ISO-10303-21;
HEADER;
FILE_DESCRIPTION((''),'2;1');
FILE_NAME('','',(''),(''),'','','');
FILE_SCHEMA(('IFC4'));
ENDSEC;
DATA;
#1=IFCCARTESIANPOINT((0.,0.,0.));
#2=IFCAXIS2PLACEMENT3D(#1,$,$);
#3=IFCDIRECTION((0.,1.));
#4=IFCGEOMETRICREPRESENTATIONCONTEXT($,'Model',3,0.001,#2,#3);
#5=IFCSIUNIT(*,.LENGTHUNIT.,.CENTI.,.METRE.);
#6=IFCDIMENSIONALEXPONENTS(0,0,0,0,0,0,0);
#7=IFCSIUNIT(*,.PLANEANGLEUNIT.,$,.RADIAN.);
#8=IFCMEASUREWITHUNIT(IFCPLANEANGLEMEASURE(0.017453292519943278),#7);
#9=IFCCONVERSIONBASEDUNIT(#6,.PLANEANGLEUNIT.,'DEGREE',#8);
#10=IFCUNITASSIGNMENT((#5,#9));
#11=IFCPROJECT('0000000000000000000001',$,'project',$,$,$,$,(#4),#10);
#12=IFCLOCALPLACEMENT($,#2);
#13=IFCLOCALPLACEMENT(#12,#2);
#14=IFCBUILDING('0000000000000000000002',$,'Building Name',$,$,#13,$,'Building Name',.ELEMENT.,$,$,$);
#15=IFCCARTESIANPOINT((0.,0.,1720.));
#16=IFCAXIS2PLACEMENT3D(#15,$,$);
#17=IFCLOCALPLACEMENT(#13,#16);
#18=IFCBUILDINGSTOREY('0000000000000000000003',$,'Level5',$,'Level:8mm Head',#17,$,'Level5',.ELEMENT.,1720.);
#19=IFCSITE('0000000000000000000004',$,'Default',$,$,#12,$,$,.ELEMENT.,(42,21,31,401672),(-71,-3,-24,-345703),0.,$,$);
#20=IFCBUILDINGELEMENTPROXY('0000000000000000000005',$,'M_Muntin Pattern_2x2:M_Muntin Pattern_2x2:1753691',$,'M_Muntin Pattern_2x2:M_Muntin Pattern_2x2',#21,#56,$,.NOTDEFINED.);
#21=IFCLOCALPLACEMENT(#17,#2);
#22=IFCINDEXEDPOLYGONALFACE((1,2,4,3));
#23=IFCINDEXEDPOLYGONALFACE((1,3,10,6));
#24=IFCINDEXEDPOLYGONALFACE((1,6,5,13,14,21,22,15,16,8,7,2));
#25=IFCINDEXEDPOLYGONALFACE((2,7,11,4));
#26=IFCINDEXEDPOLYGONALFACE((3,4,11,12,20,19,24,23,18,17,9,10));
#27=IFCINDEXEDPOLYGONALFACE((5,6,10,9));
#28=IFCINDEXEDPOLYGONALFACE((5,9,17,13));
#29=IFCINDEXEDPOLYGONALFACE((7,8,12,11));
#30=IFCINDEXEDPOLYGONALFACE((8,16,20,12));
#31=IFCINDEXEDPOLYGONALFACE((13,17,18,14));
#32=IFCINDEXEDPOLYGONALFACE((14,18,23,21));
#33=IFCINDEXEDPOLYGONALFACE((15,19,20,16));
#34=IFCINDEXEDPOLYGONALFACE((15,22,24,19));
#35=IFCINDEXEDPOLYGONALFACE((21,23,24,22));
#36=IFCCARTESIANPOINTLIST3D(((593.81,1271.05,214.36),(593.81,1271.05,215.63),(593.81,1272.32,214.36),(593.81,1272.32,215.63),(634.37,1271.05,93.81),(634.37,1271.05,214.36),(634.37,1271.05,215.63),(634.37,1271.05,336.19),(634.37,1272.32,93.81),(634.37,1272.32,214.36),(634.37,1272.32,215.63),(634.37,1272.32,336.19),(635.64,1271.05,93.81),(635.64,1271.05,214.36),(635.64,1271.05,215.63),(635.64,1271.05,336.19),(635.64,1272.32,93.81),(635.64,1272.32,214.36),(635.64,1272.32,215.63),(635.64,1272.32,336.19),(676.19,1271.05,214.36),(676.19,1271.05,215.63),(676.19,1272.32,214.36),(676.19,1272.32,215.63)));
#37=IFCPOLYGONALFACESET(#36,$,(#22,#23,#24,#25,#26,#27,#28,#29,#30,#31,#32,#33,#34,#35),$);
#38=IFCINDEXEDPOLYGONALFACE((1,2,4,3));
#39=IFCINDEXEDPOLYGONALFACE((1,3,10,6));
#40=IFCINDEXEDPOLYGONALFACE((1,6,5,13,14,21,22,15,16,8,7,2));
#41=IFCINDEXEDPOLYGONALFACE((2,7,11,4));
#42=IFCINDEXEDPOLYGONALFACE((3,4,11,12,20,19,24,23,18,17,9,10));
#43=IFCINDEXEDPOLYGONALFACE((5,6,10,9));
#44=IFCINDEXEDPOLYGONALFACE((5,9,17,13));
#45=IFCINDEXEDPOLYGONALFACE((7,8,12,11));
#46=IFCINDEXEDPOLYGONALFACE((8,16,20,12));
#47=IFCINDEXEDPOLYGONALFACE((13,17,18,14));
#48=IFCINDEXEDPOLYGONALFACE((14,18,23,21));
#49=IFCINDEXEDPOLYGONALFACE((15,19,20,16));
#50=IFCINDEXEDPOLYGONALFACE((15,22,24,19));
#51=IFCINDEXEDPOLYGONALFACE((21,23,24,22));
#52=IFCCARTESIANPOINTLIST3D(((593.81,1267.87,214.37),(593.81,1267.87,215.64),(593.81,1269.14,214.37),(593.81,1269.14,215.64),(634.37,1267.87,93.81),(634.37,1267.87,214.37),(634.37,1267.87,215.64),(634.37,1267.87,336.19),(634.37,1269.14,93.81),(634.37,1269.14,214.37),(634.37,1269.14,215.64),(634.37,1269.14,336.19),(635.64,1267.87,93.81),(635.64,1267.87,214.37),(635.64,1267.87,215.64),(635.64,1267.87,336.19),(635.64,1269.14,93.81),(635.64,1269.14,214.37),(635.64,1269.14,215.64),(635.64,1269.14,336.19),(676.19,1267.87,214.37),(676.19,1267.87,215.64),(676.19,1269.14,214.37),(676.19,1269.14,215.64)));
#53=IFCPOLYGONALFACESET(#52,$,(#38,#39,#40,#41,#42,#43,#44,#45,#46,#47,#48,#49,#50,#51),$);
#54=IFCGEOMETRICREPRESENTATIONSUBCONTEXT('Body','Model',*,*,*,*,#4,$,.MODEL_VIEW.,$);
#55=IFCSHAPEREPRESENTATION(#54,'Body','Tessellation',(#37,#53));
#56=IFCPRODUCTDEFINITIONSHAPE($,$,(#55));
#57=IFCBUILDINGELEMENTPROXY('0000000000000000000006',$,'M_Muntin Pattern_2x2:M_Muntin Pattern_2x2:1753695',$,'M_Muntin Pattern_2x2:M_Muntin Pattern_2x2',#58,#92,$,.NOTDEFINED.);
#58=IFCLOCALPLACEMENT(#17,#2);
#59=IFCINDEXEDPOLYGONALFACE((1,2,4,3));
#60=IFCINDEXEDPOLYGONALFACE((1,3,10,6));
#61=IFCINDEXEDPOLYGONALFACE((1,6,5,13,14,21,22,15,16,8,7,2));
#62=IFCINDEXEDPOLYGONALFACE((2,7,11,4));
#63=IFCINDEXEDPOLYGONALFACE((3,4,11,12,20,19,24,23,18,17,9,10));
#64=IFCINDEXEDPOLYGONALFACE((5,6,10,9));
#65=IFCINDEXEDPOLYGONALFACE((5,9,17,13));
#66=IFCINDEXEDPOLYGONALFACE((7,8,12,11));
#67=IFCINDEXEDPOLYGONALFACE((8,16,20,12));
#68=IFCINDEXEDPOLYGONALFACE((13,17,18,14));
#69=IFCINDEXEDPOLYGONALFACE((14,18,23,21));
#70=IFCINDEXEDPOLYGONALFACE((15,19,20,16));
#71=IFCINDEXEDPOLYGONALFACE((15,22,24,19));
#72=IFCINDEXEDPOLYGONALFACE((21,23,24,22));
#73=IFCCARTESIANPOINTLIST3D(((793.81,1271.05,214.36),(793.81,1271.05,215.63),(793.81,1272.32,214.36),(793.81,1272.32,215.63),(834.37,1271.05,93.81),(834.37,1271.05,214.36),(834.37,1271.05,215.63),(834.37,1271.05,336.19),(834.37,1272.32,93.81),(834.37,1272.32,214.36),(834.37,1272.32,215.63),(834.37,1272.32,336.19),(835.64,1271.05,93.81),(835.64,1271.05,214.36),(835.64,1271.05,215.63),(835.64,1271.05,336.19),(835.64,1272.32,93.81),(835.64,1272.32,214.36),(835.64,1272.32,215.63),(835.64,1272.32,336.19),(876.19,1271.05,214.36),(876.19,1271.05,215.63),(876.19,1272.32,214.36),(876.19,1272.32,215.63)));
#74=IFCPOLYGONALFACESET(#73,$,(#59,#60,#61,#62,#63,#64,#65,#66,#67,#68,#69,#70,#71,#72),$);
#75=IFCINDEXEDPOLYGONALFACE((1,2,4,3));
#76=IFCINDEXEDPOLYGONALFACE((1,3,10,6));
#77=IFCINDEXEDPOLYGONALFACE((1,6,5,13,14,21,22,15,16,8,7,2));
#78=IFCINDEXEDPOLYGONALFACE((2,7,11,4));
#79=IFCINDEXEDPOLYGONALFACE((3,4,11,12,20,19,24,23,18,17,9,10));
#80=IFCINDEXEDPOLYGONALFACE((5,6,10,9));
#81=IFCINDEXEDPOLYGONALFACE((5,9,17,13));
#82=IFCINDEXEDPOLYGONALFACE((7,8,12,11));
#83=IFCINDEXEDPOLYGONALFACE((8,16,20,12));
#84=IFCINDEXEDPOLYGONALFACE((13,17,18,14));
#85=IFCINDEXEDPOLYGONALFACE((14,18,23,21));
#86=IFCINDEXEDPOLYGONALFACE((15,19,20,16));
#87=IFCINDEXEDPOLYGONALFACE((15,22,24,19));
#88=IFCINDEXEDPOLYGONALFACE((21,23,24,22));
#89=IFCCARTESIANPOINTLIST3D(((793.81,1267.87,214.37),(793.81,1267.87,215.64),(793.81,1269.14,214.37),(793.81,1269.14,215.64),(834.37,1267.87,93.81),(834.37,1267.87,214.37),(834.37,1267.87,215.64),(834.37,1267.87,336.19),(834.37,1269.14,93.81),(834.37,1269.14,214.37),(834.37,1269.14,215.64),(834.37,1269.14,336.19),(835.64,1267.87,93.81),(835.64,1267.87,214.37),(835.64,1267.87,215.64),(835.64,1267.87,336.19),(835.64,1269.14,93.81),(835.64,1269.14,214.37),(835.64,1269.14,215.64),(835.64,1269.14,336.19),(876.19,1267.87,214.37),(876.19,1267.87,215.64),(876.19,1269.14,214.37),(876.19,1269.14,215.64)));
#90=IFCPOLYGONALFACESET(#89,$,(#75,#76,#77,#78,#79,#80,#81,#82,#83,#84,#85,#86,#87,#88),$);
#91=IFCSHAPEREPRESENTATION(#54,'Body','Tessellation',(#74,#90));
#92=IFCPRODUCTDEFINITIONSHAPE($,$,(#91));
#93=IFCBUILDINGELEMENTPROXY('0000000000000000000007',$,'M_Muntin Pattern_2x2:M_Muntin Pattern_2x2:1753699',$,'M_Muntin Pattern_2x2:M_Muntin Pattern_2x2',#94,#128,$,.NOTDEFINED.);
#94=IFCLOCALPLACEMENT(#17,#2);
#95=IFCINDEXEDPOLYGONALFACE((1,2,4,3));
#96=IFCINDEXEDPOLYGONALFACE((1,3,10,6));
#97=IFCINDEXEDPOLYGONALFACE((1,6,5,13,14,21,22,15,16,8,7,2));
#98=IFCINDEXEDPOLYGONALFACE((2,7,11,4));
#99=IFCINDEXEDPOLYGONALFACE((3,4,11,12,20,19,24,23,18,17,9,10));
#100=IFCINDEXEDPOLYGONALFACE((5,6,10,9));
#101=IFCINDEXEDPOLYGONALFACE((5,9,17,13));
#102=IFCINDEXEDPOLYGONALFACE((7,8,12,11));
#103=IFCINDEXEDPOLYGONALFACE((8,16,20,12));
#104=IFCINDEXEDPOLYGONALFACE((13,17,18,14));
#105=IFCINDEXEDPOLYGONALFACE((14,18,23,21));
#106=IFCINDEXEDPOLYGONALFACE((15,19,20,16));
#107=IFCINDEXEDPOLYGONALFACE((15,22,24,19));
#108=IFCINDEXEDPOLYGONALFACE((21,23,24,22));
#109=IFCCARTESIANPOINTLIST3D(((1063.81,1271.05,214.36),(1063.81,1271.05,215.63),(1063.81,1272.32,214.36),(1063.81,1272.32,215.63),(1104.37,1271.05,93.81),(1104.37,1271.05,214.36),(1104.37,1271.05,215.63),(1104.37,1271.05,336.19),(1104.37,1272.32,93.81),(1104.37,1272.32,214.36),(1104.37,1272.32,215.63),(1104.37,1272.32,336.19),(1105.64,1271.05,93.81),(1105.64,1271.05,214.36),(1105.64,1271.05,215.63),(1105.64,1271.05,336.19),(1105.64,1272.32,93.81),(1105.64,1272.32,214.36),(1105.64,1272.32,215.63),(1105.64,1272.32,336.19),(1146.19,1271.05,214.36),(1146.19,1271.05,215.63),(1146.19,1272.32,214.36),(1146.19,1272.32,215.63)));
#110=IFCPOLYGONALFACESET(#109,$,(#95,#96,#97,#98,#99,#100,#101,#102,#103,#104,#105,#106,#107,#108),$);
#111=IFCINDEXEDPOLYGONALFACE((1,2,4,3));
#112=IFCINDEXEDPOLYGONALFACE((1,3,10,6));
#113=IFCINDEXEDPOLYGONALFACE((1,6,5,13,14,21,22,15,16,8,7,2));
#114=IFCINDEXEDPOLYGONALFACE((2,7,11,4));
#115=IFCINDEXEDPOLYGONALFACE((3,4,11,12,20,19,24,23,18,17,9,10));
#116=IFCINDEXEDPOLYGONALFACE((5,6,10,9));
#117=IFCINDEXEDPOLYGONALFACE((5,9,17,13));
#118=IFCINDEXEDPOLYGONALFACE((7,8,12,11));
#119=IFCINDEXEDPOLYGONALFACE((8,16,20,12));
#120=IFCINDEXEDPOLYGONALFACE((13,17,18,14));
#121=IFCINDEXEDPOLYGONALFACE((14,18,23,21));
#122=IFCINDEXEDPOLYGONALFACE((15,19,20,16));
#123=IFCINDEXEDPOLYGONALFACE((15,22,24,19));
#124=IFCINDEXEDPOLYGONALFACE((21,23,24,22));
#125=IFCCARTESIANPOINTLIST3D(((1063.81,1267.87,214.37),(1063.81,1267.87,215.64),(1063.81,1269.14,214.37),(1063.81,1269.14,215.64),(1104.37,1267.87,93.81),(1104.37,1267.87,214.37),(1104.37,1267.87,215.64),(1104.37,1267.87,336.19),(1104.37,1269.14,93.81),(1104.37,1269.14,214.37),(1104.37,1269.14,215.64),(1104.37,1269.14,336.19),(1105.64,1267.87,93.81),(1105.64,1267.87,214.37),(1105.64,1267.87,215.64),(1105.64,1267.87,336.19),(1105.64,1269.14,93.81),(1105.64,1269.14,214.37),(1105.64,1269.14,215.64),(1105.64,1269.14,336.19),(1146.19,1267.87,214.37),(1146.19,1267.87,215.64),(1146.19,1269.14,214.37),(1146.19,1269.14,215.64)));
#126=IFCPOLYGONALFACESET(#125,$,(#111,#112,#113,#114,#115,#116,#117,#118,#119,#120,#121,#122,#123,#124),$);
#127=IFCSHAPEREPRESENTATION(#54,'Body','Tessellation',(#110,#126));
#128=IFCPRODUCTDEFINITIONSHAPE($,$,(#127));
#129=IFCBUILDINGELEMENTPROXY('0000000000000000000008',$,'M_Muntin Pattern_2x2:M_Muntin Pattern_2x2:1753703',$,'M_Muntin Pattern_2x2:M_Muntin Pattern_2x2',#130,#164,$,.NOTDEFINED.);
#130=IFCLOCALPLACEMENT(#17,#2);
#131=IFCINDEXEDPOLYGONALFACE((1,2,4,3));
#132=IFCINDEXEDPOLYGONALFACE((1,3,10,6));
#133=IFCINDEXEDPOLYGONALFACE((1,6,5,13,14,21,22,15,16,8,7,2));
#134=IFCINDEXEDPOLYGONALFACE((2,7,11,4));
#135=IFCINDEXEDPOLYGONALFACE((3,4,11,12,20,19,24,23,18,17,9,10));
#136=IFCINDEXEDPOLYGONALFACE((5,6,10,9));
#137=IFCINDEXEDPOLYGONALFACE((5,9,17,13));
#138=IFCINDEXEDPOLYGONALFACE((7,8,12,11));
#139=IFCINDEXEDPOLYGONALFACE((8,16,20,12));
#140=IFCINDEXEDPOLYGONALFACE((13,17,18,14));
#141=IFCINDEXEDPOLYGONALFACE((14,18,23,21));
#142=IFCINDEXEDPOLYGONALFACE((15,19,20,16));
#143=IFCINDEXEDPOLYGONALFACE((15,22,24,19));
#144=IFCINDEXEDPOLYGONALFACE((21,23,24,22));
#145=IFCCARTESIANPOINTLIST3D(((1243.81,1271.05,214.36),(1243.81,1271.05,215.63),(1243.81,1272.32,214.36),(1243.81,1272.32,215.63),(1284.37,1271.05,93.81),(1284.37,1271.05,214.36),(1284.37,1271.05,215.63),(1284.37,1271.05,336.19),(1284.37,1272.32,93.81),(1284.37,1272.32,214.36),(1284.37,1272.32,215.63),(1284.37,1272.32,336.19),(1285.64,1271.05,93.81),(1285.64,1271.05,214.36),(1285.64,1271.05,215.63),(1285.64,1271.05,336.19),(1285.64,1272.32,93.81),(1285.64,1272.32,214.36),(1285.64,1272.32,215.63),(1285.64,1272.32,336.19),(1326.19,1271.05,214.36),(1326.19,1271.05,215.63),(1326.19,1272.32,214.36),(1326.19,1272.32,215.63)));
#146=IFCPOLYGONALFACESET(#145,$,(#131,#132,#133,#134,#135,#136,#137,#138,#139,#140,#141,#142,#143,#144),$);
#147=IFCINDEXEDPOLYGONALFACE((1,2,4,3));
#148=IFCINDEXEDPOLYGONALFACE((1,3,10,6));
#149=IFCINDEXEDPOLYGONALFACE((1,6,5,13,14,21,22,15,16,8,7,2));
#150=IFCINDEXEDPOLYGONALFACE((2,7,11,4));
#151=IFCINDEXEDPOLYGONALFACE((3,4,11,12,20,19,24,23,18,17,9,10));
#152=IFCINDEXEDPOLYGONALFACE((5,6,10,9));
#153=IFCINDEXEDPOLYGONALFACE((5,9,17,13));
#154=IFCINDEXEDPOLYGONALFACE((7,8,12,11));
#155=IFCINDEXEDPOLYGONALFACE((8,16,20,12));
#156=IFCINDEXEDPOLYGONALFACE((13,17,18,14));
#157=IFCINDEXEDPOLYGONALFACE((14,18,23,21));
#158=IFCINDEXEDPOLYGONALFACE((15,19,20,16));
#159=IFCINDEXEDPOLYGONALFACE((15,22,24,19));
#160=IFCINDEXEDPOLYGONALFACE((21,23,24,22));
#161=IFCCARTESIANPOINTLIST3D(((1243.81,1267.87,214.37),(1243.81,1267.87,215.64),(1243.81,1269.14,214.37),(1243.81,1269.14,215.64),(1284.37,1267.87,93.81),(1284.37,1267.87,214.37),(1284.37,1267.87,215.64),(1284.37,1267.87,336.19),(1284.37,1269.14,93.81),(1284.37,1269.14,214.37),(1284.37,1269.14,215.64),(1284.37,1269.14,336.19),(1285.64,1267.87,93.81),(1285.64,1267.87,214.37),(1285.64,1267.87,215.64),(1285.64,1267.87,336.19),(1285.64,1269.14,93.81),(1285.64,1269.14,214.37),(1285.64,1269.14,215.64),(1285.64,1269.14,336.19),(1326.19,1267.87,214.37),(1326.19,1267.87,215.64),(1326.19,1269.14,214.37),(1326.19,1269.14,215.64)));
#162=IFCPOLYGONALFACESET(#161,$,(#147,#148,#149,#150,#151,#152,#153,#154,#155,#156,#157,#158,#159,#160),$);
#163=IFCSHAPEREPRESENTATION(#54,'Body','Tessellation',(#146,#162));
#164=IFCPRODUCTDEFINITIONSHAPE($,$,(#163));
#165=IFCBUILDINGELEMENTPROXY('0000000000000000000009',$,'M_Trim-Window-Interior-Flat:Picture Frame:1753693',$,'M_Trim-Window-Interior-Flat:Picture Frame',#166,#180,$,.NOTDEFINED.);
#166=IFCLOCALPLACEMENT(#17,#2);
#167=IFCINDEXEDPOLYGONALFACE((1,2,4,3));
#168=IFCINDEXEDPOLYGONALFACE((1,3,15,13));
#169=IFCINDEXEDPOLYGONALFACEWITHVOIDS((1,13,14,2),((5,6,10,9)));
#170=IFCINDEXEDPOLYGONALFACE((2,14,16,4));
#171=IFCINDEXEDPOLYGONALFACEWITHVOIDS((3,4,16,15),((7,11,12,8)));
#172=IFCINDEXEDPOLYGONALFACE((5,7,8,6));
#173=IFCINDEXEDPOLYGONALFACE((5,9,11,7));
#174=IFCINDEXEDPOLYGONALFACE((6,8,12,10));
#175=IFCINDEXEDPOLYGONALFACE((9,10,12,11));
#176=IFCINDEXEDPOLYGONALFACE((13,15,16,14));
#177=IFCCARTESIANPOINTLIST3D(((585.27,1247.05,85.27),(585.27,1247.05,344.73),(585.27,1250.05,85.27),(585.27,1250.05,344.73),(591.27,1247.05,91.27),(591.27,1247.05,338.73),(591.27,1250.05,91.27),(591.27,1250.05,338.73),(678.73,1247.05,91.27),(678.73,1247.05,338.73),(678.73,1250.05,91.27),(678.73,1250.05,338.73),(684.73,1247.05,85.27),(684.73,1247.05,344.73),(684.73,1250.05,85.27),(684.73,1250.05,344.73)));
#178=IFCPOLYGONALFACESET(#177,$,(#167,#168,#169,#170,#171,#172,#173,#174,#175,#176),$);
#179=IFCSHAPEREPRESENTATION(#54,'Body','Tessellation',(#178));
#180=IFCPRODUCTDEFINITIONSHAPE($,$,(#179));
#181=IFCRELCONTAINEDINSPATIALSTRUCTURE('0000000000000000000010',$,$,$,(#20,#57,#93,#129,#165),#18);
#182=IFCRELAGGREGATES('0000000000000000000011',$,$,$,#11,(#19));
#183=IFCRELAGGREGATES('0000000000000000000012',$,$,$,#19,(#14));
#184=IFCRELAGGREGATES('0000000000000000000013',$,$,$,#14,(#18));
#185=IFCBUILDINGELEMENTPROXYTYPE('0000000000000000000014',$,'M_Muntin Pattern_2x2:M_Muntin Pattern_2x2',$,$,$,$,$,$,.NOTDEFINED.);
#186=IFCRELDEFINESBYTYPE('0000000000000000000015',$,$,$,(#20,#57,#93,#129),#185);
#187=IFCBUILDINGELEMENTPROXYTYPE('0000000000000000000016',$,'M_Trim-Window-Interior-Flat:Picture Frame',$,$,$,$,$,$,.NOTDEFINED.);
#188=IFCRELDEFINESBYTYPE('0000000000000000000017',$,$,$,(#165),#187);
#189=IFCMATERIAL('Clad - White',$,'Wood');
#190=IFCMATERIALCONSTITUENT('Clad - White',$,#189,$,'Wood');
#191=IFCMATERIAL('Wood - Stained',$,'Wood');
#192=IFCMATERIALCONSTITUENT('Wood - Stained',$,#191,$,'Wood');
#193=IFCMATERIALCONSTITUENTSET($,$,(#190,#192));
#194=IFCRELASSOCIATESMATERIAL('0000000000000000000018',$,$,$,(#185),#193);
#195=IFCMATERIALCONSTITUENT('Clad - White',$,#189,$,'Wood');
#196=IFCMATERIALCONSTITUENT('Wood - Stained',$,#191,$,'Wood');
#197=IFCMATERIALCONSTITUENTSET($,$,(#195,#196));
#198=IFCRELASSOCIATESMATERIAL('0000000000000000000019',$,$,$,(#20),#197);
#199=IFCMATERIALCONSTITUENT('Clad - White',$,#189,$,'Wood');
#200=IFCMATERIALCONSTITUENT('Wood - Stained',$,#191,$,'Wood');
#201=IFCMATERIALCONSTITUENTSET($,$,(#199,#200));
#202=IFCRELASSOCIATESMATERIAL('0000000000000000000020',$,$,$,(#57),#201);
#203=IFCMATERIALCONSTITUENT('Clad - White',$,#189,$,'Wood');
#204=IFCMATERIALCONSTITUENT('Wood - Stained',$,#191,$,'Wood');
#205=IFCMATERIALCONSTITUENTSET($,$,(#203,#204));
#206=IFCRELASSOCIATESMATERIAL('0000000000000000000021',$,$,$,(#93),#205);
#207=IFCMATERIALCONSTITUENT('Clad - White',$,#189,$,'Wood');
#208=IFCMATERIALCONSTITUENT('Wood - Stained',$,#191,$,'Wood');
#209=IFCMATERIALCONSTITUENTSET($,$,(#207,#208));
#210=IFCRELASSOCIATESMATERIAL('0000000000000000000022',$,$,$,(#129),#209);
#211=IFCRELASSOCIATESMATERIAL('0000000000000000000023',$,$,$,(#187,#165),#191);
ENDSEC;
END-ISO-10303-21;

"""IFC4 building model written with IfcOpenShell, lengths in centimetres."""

from ifc_helpers import new_model, entity, si_unit, converted_unit, direction, frame, origin, place, context, subcontext, project, spatial, indexed_curve, outline, extrude, source, transform, mapped, material, constituent, constituent_set, type_object, type_shapes, element, save


model = new_model("IFC4")

# Units and contexts
model_context = context("Model", 3, precision=0.001, world=origin(), true_north=direction((0.0, 1.0)))
body_context = subcontext(model_context, "Body", "Model", "MODEL_VIEW")
ifc_project = project(units=[si_unit("LENGTHUNIT", "METRE", prefix="CENTI"), converted_unit("PLANEANGLEUNIT", "DEGREE", entity("IfcPlaneAngleMeasure", 0.017453292519943278), si_unit("PLANEANGLEUNIT", "RADIAN"), dimensions=[0, 0, 0, 0, 0, 0, 0])], contexts=[model_context])

# Site, building, storey
site_placement = place(None, origin())
site = spatial("IfcSite", under=ifc_project, at=site_placement, Name="Default", CompositionType="ELEMENT", RefLatitude=(42, 21, 31, 401672), RefLongitude=(-71, -3, -24, -345703), RefElevation=0.0)
building_placement = place(site_placement, origin())
building = spatial("IfcBuilding", under=site, at=building_placement, Name="Building Name", LongName="Building Name", CompositionType="ELEMENT")
storey_placement = place(building_placement, frame((0.0, 0.0, 1720.0)))
storey = spatial("IfcBuildingStorey", under=building, at=storey_placement, Name="Level5", ObjectType="Level:8mm Head", LongName="Level5", CompositionType="ELEMENT", Elevation=1720.0)

# Building element proxies
ifc_material_1 = material(Name="Clad - White", Category="Wood")
ifc_material_2 = material(Name="Wood - Stained", Category="Wood")
ifc_constituent_1 = constituent(ifc_material_1, Name="Clad - White", Category="Wood")
ifc_constituent_2 = constituent(ifc_material_2, Name="Wood - Stained", Category="Wood")
ifc_constituent_set_1 = constituent_set(constituents=[ifc_constituent_1, ifc_constituent_2])
ifc_constituent_3 = constituent(ifc_material_1, Name="Clad - White", Category="Wood")
ifc_constituent_4 = constituent(ifc_material_2, Name="Wood - Stained", Category="Wood")
ifc_constituent_set_2 = constituent_set(constituents=[ifc_constituent_3, ifc_constituent_4])
building_element_proxy_type_1 = type_object("IfcBuildingElementProxyType", Name="M_Muntin Pattern_2x2:M_Muntin Pattern_2x2", PredefinedType="NOTDEFINED", material=ifc_constituent_set_2)
shared_shape_1 = source(origin(), body_context, "Body", "SweptSolid", [
    extrude(outline(indexed_curve([(0.64, -0.64), (121.19, -0.64), (121.19, 0.63), (0.64, 0.63), (0.64, 41.19), (-0.63, 41.19), (-0.63, 0.63), (-121.19, 0.63), (-121.19, -0.64), (-0.63, -0.64), (-0.63, -41.19), (0.64, -41.19), (0.64, -0.64)], self_intersect=False)), frame((0.0, -2.22, 121.19), z_axis=(0.0, 1.0, 0.0), x_axis=(0.0, 0.0, 1.0)), (0.0, 0.0, 1.0), 1.27),
    extrude(outline(indexed_curve([(0.64, -0.64), (121.19, -0.64), (121.19, 0.63), (0.64, 0.63), (0.64, 41.19), (-0.63, 41.19), (-0.63, 0.63), (-121.19, 0.63), (-121.19, -0.64), (-0.63, -0.64), (-0.63, -41.19), (0.64, -41.19), (0.64, -0.64)], self_intersect=False)), frame((0.0, 0.95, 121.19), z_axis=(0.0, 1.0, 0.0), x_axis=(0.0, 0.0, 1.0)), (0.0, 0.0, 1.0), 1.27),
])
type_shapes(building_element_proxy_type_1, [shared_shape_1])
proxy_1_placement = place(storey_placement, frame((635.0, 1270.1, 93.81), z_axis=(0.0, 0.0, 1.0), x_axis=(-1.0, 0.0, 0.0)))
element("IfcBuildingElementProxy", 1, at=proxy_1_placement, inside=storey, type_object=building_element_proxy_type_1, material=ifc_constituent_set_1, Name="M_Muntin Pattern_2x2:M_Muntin Pattern_2x2:1753691", ObjectType="M_Muntin Pattern_2x2:M_Muntin Pattern_2x2", PredefinedType="NOTDEFINED", context=body_context, shape_type="MappedRepresentation", body=[
    mapped(shared_shape_1, transform((0.0, 0.0, 0.0), scale=1.0)),
])
ifc_constituent_5 = constituent(ifc_material_1, Name="Clad - White", Category="Wood")
ifc_constituent_6 = constituent(ifc_material_2, Name="Wood - Stained", Category="Wood")
ifc_constituent_set_3 = constituent_set(constituents=[ifc_constituent_5, ifc_constituent_6])
proxy_2_placement = place(storey_placement, frame((835.0, 1270.1, 93.81), z_axis=(0.0, 0.0, 1.0), x_axis=(-1.0, 0.0, 0.0)))
element("IfcBuildingElementProxy", 2, at=proxy_2_placement, inside=storey, type_object=building_element_proxy_type_1, material=ifc_constituent_set_3, Name="M_Muntin Pattern_2x2:M_Muntin Pattern_2x2:1753695", ObjectType="M_Muntin Pattern_2x2:M_Muntin Pattern_2x2", PredefinedType="NOTDEFINED", context=body_context, shape_type="MappedRepresentation", body=[
    mapped(shared_shape_1, transform((0.0, 0.0, 0.0), scale=1.0)),
])
ifc_constituent_7 = constituent(ifc_material_1, Name="Clad - White", Category="Wood")
ifc_constituent_8 = constituent(ifc_material_2, Name="Wood - Stained", Category="Wood")
ifc_constituent_set_4 = constituent_set(constituents=[ifc_constituent_7, ifc_constituent_8])
proxy_3_placement = place(storey_placement, frame((1105.0, 1270.1, 93.81), z_axis=(0.0, 0.0, 1.0), x_axis=(-1.0, 0.0, 0.0)))
element("IfcBuildingElementProxy", 3, at=proxy_3_placement, inside=storey, type_object=building_element_proxy_type_1, material=ifc_constituent_set_4, Name="M_Muntin Pattern_2x2:M_Muntin Pattern_2x2:1753699", ObjectType="M_Muntin Pattern_2x2:M_Muntin Pattern_2x2", PredefinedType="NOTDEFINED", context=body_context, shape_type="MappedRepresentation", body=[
    mapped(shared_shape_1, transform((0.0, 0.0, 0.0), scale=1.0)),
])
ifc_constituent_9 = constituent(ifc_material_1, Name="Clad - White", Category="Wood")
ifc_constituent_10 = constituent(ifc_material_2, Name="Wood - Stained", Category="Wood")
ifc_constituent_set_5 = constituent_set(constituents=[ifc_constituent_9, ifc_constituent_10])
proxy_4_placement = place(storey_placement, frame((1285.0, 1270.1, 93.81), z_axis=(0.0, 0.0, 1.0), x_axis=(-1.0, 0.0, 0.0)))
element("IfcBuildingElementProxy", 4, at=proxy_4_placement, inside=storey, type_object=building_element_proxy_type_1, material=ifc_constituent_set_5, Name="M_Muntin Pattern_2x2:M_Muntin Pattern_2x2:1753703", ObjectType="M_Muntin Pattern_2x2:M_Muntin Pattern_2x2", PredefinedType="NOTDEFINED", context=body_context, shape_type="MappedRepresentation", body=[
    mapped(shared_shape_1, transform((0.0, 0.0, 0.0), scale=1.0)),
])
building_element_proxy_type_2 = type_object("IfcBuildingElementProxyType", Name="M_Trim-Window-Interior-Flat:Picture Frame", PredefinedType="NOTDEFINED", material=ifc_material_2)
shared_shape_2 = source(origin(), body_context, "Body", "SweptSolid", [
    extrude(outline(indexed_curve([(-49.73, -129.73), (49.73, -129.73), (49.73, 129.73), (-49.73, 129.73), (-49.73, -129.73)], self_intersect=False), holes=[indexed_curve([(-43.73, -123.73), (-43.73, 123.73), (43.73, 123.73), (43.73, -123.73), (-43.73, -123.73)], self_intersect=False)]), frame((0.0, -125.0, 0.0), z_axis=(0.0, 0.0, 1.0), x_axis=(-1.0, 0.0, 0.0)), (0.0, 0.0, 1.0), 3.0),
])
type_shapes(building_element_proxy_type_2, [shared_shape_2])
for number, where, z_axis, x_axis, name in (
    (5, (635.0, 1250.05, 340.0), (0.0, -1.0, 0.0), (1.0, 0.0, 0.0), "M_Trim-Window-Interior-Flat:Picture Frame:1753693"),
):
    element("IfcBuildingElementProxy", number, at=place(storey_placement, frame(where, z_axis=z_axis, x_axis=x_axis)), inside=storey, type_object=building_element_proxy_type_2, material=ifc_material_2, Name=name, ObjectType="M_Trim-Window-Interior-Flat:Picture Frame", PredefinedType="NOTDEFINED", context=body_context, shape_type="MappedRepresentation", body=[
        mapped(shared_shape_2, transform((0.0, 0.0, 0.0), scale=1.0)),
    ])

save(model, "model.ifc")
